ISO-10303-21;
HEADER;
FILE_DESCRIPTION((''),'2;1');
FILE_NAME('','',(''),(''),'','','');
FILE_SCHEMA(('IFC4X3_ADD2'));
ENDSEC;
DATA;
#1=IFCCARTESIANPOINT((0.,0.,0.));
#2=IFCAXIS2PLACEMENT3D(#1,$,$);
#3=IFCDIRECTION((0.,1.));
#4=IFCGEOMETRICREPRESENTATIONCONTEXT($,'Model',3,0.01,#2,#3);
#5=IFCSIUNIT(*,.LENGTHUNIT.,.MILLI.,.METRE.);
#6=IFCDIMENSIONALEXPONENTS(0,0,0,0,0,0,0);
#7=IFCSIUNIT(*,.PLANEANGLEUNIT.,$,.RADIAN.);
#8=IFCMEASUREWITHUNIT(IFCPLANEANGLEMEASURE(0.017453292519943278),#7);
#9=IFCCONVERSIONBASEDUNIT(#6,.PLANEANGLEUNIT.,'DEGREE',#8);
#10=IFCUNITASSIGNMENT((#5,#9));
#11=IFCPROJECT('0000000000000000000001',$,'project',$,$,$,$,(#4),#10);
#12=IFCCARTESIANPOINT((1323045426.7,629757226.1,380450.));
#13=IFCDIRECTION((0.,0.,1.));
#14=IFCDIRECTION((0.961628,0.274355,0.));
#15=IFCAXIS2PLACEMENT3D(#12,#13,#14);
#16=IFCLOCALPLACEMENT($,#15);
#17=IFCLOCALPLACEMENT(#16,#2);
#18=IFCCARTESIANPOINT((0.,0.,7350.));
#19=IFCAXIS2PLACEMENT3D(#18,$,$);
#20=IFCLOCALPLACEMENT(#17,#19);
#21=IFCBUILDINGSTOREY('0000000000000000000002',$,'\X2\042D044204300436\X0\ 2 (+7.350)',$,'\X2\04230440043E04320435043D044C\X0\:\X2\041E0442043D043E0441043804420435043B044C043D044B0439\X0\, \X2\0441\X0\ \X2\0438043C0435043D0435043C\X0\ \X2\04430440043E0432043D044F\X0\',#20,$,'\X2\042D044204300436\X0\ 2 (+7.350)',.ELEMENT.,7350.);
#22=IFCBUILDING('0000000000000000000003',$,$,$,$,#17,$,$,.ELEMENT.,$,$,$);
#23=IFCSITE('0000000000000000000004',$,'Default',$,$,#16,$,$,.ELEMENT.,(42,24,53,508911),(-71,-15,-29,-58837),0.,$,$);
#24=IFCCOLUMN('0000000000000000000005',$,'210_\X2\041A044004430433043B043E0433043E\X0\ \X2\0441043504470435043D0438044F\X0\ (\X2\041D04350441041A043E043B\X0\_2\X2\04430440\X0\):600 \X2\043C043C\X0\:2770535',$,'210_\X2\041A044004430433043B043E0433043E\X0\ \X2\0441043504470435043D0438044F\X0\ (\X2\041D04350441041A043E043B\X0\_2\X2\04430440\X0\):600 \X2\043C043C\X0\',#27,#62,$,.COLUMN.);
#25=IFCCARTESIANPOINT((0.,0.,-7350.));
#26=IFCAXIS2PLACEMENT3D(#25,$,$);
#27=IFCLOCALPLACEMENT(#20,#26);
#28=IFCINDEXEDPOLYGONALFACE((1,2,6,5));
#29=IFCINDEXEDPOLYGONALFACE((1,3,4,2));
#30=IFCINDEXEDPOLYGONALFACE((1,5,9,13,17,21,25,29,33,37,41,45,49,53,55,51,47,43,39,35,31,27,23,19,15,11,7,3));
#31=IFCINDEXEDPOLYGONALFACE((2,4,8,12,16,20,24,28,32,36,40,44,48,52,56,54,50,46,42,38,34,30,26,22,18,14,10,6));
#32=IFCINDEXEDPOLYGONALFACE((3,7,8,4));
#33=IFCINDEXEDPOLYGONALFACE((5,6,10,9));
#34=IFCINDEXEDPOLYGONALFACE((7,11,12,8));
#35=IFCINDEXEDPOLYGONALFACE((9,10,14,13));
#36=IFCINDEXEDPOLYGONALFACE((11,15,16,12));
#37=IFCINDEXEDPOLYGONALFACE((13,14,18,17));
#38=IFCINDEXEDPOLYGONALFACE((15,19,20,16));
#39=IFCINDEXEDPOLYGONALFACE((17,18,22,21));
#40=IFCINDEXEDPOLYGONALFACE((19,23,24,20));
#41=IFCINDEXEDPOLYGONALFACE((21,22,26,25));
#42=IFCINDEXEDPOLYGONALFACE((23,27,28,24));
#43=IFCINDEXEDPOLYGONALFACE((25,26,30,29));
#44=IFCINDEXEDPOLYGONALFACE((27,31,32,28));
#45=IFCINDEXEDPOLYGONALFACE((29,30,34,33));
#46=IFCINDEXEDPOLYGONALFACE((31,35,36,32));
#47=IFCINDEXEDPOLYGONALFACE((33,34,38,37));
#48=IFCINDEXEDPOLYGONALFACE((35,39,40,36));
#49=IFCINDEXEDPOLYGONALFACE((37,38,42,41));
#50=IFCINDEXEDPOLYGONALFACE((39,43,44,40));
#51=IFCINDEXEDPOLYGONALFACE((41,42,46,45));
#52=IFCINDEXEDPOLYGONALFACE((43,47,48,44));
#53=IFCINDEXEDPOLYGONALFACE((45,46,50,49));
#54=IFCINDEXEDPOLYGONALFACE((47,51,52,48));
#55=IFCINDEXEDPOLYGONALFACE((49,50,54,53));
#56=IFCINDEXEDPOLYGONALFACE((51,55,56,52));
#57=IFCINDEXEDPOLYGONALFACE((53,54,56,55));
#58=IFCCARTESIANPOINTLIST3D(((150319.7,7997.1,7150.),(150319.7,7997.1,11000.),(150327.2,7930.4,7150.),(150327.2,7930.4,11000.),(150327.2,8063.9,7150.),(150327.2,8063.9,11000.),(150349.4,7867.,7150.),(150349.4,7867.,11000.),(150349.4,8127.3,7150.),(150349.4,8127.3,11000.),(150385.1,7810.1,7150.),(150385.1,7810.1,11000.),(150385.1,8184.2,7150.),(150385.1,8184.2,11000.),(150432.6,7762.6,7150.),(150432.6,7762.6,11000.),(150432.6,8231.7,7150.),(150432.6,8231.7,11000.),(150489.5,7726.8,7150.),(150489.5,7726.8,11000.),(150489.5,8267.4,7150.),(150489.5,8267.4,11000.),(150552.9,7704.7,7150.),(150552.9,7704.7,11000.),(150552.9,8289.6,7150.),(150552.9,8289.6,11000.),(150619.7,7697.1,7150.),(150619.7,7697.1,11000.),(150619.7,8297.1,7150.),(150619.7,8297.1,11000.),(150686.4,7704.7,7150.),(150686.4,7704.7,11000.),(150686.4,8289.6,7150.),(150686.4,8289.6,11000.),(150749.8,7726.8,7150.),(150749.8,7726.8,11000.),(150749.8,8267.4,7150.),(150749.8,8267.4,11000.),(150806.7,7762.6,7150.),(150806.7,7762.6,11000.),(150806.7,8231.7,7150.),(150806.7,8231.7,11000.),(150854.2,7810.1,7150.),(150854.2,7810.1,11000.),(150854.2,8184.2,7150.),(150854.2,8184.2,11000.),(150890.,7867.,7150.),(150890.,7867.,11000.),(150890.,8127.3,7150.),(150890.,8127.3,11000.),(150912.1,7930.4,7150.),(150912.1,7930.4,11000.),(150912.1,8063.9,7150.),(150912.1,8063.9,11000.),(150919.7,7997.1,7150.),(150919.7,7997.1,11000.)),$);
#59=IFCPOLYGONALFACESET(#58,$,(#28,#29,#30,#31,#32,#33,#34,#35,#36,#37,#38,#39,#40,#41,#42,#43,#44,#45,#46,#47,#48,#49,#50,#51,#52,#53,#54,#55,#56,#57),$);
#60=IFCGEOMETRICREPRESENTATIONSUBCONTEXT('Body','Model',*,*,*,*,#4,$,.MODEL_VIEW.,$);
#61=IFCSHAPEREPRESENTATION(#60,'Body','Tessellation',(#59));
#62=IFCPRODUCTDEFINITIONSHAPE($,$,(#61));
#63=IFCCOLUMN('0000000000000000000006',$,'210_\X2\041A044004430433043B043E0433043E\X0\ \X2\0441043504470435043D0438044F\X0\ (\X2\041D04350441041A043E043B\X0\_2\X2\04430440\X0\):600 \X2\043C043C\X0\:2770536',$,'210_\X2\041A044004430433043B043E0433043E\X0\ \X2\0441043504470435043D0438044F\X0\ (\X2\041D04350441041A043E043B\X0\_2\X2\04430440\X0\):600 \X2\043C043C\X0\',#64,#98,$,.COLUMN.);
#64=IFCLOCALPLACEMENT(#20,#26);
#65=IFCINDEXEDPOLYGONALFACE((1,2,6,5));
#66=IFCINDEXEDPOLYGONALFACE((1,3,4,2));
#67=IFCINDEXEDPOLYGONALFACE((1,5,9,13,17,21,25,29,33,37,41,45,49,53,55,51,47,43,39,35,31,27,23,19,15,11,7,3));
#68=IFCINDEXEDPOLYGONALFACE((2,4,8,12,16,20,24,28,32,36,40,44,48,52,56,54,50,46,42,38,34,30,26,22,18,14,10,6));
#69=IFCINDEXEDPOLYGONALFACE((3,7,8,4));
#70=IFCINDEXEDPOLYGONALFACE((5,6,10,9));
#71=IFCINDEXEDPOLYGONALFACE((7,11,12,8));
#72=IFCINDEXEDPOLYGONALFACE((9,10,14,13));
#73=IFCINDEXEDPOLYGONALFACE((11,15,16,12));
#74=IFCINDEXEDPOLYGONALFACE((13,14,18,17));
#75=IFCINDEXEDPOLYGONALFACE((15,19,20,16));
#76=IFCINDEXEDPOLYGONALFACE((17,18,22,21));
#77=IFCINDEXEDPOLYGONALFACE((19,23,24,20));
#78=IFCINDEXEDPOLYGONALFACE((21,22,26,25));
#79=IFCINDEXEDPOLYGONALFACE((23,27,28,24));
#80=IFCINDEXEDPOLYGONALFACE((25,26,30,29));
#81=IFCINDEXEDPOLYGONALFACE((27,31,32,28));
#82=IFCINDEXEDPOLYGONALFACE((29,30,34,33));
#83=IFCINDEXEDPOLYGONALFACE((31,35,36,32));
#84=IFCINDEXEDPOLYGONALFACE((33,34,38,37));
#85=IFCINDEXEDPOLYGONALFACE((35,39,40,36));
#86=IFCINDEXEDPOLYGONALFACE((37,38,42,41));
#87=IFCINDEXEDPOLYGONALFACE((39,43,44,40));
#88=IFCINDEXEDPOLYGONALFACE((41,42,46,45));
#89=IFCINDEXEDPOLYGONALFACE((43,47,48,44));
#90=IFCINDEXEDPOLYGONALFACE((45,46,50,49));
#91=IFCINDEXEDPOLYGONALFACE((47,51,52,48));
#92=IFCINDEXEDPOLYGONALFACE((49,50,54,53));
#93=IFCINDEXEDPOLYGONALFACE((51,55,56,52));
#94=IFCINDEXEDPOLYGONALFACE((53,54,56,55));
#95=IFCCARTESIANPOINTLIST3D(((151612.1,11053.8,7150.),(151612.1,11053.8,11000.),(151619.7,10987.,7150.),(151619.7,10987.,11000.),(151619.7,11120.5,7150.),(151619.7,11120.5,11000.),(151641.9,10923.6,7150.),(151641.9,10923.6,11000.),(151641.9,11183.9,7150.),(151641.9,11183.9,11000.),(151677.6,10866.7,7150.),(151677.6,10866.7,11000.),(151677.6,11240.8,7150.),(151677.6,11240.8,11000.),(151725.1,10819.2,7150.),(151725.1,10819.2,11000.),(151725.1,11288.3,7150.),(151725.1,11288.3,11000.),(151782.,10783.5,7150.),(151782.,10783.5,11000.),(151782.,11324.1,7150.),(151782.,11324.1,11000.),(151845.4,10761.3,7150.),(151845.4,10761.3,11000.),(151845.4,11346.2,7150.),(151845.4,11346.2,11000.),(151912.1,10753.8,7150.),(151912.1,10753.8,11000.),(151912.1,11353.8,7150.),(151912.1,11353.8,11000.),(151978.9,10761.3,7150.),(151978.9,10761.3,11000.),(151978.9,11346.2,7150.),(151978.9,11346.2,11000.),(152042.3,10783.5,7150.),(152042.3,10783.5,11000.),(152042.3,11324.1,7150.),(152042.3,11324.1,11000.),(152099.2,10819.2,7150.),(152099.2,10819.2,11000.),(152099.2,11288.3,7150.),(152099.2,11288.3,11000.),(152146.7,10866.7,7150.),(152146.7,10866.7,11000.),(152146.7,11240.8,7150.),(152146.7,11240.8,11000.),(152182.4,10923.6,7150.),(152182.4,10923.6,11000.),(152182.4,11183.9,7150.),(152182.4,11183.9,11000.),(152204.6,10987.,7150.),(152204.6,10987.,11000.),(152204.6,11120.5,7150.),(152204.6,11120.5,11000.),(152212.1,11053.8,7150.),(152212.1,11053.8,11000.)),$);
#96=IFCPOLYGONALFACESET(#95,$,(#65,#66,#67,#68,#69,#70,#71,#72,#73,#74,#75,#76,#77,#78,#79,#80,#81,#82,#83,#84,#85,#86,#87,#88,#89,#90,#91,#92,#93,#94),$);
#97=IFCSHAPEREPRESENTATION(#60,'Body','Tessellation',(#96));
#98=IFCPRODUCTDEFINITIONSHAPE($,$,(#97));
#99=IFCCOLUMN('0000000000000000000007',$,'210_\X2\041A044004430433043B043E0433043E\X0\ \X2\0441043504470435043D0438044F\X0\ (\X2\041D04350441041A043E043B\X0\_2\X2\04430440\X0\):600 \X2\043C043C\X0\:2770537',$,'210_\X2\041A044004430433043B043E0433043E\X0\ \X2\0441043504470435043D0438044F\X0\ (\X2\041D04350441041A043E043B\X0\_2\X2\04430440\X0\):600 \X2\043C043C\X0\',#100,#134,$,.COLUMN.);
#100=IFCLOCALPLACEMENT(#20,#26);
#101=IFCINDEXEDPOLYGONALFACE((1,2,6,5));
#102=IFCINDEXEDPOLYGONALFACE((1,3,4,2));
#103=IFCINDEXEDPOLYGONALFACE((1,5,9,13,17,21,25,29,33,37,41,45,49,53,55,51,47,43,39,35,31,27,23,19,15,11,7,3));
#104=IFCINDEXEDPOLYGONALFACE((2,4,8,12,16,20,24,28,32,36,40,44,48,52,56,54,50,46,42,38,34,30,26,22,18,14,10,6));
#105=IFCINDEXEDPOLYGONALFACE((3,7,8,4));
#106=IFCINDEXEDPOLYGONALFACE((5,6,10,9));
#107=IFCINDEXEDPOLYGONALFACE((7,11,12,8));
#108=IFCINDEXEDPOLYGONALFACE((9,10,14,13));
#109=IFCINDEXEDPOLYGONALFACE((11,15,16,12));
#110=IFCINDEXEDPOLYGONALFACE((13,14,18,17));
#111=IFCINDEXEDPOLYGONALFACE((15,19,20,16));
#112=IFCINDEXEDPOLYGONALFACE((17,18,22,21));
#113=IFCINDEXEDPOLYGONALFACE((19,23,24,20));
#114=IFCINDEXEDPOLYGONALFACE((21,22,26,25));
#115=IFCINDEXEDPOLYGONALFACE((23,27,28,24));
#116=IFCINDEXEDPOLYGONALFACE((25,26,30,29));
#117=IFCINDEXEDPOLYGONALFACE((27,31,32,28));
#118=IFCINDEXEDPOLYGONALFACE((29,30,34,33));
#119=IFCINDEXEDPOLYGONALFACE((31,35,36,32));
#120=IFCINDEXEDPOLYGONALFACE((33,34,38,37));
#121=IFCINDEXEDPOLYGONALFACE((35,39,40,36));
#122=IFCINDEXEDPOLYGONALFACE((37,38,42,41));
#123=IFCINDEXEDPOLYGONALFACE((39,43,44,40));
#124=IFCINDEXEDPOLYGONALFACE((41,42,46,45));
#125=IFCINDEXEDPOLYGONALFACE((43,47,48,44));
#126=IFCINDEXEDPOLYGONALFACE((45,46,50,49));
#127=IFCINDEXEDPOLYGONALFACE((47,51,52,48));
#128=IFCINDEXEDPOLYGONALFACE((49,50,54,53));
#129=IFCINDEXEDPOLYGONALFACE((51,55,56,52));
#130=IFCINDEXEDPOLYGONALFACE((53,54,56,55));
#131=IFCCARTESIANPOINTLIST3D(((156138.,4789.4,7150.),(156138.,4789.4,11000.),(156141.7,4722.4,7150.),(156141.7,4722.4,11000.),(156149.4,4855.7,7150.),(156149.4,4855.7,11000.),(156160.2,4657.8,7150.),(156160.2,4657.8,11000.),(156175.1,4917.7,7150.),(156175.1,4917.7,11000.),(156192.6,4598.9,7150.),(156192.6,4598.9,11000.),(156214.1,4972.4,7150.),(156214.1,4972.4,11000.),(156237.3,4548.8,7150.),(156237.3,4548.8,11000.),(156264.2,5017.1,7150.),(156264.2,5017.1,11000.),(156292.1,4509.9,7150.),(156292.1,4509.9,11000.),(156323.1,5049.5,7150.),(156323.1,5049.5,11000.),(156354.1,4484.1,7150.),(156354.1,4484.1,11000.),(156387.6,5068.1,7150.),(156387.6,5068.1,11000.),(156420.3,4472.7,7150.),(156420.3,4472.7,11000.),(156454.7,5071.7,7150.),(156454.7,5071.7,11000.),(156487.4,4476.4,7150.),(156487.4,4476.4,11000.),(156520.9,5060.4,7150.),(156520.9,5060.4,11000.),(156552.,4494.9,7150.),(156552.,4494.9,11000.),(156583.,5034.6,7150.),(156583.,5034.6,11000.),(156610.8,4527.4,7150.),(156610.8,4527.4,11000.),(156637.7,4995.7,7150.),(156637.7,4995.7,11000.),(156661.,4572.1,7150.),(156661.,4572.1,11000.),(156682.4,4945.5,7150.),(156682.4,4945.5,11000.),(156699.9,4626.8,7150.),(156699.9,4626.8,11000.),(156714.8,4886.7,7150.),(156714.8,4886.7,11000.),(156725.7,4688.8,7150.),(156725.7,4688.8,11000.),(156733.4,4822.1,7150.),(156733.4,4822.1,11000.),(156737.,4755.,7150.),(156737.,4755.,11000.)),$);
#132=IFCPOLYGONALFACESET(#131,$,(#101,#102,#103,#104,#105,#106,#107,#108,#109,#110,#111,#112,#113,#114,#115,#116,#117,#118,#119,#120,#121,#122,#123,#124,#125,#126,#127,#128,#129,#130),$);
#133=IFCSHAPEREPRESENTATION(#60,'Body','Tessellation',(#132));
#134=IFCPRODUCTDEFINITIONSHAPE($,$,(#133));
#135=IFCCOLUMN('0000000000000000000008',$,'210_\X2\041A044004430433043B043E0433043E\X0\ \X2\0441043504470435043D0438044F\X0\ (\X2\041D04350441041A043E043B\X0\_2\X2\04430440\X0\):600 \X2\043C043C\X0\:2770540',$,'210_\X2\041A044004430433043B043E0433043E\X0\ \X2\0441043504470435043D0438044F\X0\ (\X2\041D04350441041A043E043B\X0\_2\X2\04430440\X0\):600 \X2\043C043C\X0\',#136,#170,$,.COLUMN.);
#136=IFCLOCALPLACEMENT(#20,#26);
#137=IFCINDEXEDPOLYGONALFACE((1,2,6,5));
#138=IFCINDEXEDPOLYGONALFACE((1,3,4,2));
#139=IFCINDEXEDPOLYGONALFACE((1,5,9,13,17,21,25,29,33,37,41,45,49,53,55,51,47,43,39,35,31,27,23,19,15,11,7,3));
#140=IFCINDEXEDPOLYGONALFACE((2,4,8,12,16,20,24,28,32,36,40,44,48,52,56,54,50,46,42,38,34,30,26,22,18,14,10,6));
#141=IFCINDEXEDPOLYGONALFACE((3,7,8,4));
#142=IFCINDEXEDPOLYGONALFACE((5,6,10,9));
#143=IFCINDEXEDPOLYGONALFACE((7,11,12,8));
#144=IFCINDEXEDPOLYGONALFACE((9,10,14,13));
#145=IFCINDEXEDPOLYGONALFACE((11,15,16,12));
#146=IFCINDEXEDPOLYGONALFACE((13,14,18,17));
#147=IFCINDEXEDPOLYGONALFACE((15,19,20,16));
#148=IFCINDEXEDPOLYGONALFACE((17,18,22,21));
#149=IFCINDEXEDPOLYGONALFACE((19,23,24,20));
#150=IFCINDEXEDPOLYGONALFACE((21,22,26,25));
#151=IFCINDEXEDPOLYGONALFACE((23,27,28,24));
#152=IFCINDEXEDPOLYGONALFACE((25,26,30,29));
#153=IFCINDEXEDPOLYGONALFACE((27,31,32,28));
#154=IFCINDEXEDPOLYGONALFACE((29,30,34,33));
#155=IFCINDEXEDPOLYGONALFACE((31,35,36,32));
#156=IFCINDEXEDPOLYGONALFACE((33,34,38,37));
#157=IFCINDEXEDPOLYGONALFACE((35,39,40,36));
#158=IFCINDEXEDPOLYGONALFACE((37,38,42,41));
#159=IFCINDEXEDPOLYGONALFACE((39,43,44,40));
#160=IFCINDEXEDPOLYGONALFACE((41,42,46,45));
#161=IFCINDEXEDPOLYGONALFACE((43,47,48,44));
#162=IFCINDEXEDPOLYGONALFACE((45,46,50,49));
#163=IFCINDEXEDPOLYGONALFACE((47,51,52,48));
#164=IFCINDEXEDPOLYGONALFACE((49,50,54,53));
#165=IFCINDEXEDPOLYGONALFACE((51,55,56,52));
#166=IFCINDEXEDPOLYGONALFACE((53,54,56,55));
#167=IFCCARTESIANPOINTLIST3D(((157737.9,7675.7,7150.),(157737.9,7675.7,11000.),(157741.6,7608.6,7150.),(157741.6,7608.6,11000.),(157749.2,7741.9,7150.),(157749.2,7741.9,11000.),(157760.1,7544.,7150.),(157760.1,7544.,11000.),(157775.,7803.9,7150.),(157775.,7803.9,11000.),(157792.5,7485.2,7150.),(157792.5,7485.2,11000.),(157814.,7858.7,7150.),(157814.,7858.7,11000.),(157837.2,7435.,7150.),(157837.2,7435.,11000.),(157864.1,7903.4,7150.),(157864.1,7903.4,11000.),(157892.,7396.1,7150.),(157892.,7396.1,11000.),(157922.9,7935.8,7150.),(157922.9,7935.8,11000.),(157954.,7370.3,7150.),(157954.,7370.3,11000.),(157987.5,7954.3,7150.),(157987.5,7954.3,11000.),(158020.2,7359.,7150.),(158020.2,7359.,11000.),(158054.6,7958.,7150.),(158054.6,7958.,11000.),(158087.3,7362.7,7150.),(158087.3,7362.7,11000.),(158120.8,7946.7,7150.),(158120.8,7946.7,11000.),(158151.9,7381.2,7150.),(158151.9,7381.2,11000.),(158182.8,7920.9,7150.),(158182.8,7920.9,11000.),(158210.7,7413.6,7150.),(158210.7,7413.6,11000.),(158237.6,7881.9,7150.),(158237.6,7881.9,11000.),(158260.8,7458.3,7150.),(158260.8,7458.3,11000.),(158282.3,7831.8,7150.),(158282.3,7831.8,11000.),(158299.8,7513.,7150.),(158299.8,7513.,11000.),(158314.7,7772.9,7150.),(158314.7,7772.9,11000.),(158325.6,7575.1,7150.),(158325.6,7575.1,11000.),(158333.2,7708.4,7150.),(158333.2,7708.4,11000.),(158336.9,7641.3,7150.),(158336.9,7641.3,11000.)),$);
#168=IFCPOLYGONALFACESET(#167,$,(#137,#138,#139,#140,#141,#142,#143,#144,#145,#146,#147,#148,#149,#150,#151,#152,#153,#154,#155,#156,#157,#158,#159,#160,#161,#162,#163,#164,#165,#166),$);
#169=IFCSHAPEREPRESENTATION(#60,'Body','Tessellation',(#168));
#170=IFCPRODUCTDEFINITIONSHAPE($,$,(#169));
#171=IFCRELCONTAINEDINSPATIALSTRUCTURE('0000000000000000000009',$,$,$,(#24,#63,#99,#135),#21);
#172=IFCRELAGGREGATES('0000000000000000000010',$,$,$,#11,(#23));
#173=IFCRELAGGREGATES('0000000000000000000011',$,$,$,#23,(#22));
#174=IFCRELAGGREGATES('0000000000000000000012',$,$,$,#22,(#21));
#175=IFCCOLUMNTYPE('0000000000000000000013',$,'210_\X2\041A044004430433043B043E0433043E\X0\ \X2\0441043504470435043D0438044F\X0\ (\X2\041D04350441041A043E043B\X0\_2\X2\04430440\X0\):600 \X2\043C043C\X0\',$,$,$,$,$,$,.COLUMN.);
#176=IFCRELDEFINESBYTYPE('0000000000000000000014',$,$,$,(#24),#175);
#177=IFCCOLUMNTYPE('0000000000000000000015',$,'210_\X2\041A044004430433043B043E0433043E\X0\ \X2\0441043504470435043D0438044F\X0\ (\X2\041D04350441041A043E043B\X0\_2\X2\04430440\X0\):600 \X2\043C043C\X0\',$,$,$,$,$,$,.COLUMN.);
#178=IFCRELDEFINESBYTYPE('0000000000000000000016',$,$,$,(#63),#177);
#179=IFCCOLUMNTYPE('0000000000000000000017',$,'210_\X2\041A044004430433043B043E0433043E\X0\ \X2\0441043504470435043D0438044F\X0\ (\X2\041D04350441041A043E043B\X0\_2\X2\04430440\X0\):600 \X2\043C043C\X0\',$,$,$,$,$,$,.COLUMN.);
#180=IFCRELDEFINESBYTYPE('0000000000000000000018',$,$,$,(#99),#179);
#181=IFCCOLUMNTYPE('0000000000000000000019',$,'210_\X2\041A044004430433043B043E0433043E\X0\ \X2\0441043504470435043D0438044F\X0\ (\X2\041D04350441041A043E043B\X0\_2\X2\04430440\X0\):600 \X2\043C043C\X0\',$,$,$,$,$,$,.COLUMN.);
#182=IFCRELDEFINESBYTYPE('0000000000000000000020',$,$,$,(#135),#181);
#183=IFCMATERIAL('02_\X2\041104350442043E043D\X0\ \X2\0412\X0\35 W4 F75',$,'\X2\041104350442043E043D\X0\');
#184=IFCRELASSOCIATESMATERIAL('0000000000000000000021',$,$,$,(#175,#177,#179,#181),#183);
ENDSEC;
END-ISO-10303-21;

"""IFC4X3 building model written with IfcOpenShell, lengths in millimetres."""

from ifc_helpers import new_model, entity, si_unit, converted_unit, direction, frame, frame_2d, origin, origin_2d_with_axis, place, context, subcontext, project, spatial, circle, extrude, source, transform, mapped, material, material_profile, profile_set, type_object, type_shapes, element, save


model = new_model("IFC4X3")

# Units and contexts
model_context = context("Model", 3, precision=0.01, world=origin(), true_north=direction((0.0, 1.0)))
body_context = subcontext(model_context, "Body", "Model", "MODEL_VIEW")
ifc_project = project(units=[si_unit("LENGTHUNIT", "METRE", prefix="MILLI"), converted_unit("PLANEANGLEUNIT", "DEGREE", entity("IfcPlaneAngleMeasure", 0.017453292519943278), si_unit("PLANEANGLEUNIT", "RADIAN"), dimensions=[0, 0, 0, 0, 0, 0, 0])], contexts=[model_context])

# Site, building, storey
site_placement = place(None, frame((1323045426.7, 629757226.1, 380450.0), z_axis=(0.0, 0.0, 1.0), x_axis=(0.961628, 0.274355, 0.0)))
site = spatial("IfcSite", under=ifc_project, at=site_placement, Name="Default", CompositionType="ELEMENT", RefLatitude=(42, 24, 53, 508911), RefLongitude=(-71, -15, -29, -58837), RefElevation=0.0)
building_placement = place(site_placement, origin())
building = spatial("IfcBuilding", under=site, at=building_placement, CompositionType="ELEMENT")
storey_placement = place(building_placement, frame((0.0, 0.0, 7350.0)))
storey = spatial("IfcBuildingStorey", under=building, at=storey_placement, Name="Этаж 2 (+7.350)", ObjectType="Уровень:Относительный, с именем уровня", LongName="Этаж 2 (+7.350)", CompositionType="ELEMENT", Elevation=7350.0)

# Columns
ifc_material = material(Name="02_Бетон В35 W4 F75", Category="Бетон")
ifc_material_profile_1 = material_profile(ifc_material, circle(Radius=300.0, at=origin_2d_with_axis()), Name="600 мм")
ifc_profile_set_1 = profile_set([ifc_material_profile_1], Name="600 мм")
column_type_1 = type_object("IfcColumnType", Name="210_Круглого сечения (НесКол_2ур):600 мм", PredefinedType="COLUMN", material=ifc_profile_set_1)
shared_shape_1 = source(origin(), body_context, "Body", "SweptSolid", [
    extrude(circle(Radius=300.0, at=origin_2d_with_axis()), frame((150619.7, 7997.1, 7150.0)), (0.0, 0.0, 1.0), 3850.0),
])
type_shapes(column_type_1, [shared_shape_1])
column_1_placement = place(storey_placement, frame((0.0, 0.0, -7350.0)))
element("IfcColumn", 1, at=column_1_placement, inside=storey, type_object=column_type_1, Name="210_Круглого сечения (НесКол_2ур):600 мм:2770535", ObjectType="210_Круглого сечения (НесКол_2ур):600 мм", PredefinedType="COLUMN", context=body_context, shape_type="MappedRepresentation", body=[
    mapped(shared_shape_1, transform((0.0, 0.0, 0.0), scale=1.0)),
])
column_type_2 = type_object("IfcColumnType", Name="210_Круглого сечения (НесКол_2ур):600 мм", PredefinedType="COLUMN", material=ifc_profile_set_1)
shared_shape_2 = source(origin(), body_context, "Body", "SweptSolid", [
    extrude(circle(Radius=300.0, at=origin_2d_with_axis()), frame((151912.1, 11053.8, 7150.0)), (0.0, 0.0, 1.0), 3850.0),
])
type_shapes(column_type_2, [shared_shape_2])
column_2_placement = place(storey_placement, frame((0.0, 0.0, -7350.0)))
element("IfcColumn", 2, at=column_2_placement, inside=storey, type_object=column_type_2, Name="210_Круглого сечения (НесКол_2ур):600 мм:2770536", ObjectType="210_Круглого сечения (НесКол_2ур):600 мм", PredefinedType="COLUMN", context=body_context, shape_type="MappedRepresentation", body=[
    mapped(shared_shape_2, transform((0.0, 0.0, 0.0), scale=1.0)),
])
column_type_3 = type_object("IfcColumnType", Name="210_Круглого сечения (НесКол_2ур):600 мм", PredefinedType="COLUMN", material=ifc_profile_set_1)
shared_shape_3 = source(origin(), body_context, "Body", "SweptSolid", [
    extrude(circle(Radius=300.0, at=frame_2d((0.0, 0.0), x_axis=(1.0, 0.0))), frame((156437.5, 4772.2, 7150.0), z_axis=(0.0, 0.0, 1.0), x_axis=(0.87462, -0.48481, 0.0)), (0.0, 0.0, 1.0), 3850.0),
])
type_shapes(column_type_3, [shared_shape_3])
column_3_placement = place(storey_placement, frame((0.0, 0.0, -7350.0)))
element("IfcColumn", 3, at=column_3_placement, inside=storey, type_object=column_type_3, Name="210_Круглого сечения (НесКол_2ур):600 мм:2770537", ObjectType="210_Круглого сечения (НесКол_2ур):600 мм", PredefinedType="COLUMN", context=body_context, shape_type="MappedRepresentation", body=[
    mapped(shared_shape_3, transform((0.0, 0.0, 0.0), scale=1.0)),
])
column_type_4 = type_object("IfcColumnType", Name="210_Круглого сечения (НесКол_2ур):600 мм", PredefinedType="COLUMN", material=ifc_profile_set_1)
shared_shape_4 = source(origin(), body_context, "Body", "SweptSolid", [
    extrude(circle(Radius=300.0, at=origin_2d_with_axis()), frame((158037.4, 7658.5, 7150.0), z_axis=(0.0, 0.0, 1.0), x_axis=(0.87462, -0.48481, 0.0)), (0.0, 0.0, 1.0), 3850.0),
])
type_shapes(column_type_4, [shared_shape_4])
column_4_placement = place(storey_placement, frame((0.0, 0.0, -7350.0)))
element("IfcColumn", 4, at=column_4_placement, inside=storey, type_object=column_type_4, Name="210_Круглого сечения (НесКол_2ур):600 мм:2770540", ObjectType="210_Круглого сечения (НесКол_2ур):600 мм", PredefinedType="COLUMN", context=body_context, shape_type="MappedRepresentation", body=[
    mapped(shared_shape_4, transform((0.0, 0.0, 0.0), scale=1.0)),
])

save(model, "model.ifc")
